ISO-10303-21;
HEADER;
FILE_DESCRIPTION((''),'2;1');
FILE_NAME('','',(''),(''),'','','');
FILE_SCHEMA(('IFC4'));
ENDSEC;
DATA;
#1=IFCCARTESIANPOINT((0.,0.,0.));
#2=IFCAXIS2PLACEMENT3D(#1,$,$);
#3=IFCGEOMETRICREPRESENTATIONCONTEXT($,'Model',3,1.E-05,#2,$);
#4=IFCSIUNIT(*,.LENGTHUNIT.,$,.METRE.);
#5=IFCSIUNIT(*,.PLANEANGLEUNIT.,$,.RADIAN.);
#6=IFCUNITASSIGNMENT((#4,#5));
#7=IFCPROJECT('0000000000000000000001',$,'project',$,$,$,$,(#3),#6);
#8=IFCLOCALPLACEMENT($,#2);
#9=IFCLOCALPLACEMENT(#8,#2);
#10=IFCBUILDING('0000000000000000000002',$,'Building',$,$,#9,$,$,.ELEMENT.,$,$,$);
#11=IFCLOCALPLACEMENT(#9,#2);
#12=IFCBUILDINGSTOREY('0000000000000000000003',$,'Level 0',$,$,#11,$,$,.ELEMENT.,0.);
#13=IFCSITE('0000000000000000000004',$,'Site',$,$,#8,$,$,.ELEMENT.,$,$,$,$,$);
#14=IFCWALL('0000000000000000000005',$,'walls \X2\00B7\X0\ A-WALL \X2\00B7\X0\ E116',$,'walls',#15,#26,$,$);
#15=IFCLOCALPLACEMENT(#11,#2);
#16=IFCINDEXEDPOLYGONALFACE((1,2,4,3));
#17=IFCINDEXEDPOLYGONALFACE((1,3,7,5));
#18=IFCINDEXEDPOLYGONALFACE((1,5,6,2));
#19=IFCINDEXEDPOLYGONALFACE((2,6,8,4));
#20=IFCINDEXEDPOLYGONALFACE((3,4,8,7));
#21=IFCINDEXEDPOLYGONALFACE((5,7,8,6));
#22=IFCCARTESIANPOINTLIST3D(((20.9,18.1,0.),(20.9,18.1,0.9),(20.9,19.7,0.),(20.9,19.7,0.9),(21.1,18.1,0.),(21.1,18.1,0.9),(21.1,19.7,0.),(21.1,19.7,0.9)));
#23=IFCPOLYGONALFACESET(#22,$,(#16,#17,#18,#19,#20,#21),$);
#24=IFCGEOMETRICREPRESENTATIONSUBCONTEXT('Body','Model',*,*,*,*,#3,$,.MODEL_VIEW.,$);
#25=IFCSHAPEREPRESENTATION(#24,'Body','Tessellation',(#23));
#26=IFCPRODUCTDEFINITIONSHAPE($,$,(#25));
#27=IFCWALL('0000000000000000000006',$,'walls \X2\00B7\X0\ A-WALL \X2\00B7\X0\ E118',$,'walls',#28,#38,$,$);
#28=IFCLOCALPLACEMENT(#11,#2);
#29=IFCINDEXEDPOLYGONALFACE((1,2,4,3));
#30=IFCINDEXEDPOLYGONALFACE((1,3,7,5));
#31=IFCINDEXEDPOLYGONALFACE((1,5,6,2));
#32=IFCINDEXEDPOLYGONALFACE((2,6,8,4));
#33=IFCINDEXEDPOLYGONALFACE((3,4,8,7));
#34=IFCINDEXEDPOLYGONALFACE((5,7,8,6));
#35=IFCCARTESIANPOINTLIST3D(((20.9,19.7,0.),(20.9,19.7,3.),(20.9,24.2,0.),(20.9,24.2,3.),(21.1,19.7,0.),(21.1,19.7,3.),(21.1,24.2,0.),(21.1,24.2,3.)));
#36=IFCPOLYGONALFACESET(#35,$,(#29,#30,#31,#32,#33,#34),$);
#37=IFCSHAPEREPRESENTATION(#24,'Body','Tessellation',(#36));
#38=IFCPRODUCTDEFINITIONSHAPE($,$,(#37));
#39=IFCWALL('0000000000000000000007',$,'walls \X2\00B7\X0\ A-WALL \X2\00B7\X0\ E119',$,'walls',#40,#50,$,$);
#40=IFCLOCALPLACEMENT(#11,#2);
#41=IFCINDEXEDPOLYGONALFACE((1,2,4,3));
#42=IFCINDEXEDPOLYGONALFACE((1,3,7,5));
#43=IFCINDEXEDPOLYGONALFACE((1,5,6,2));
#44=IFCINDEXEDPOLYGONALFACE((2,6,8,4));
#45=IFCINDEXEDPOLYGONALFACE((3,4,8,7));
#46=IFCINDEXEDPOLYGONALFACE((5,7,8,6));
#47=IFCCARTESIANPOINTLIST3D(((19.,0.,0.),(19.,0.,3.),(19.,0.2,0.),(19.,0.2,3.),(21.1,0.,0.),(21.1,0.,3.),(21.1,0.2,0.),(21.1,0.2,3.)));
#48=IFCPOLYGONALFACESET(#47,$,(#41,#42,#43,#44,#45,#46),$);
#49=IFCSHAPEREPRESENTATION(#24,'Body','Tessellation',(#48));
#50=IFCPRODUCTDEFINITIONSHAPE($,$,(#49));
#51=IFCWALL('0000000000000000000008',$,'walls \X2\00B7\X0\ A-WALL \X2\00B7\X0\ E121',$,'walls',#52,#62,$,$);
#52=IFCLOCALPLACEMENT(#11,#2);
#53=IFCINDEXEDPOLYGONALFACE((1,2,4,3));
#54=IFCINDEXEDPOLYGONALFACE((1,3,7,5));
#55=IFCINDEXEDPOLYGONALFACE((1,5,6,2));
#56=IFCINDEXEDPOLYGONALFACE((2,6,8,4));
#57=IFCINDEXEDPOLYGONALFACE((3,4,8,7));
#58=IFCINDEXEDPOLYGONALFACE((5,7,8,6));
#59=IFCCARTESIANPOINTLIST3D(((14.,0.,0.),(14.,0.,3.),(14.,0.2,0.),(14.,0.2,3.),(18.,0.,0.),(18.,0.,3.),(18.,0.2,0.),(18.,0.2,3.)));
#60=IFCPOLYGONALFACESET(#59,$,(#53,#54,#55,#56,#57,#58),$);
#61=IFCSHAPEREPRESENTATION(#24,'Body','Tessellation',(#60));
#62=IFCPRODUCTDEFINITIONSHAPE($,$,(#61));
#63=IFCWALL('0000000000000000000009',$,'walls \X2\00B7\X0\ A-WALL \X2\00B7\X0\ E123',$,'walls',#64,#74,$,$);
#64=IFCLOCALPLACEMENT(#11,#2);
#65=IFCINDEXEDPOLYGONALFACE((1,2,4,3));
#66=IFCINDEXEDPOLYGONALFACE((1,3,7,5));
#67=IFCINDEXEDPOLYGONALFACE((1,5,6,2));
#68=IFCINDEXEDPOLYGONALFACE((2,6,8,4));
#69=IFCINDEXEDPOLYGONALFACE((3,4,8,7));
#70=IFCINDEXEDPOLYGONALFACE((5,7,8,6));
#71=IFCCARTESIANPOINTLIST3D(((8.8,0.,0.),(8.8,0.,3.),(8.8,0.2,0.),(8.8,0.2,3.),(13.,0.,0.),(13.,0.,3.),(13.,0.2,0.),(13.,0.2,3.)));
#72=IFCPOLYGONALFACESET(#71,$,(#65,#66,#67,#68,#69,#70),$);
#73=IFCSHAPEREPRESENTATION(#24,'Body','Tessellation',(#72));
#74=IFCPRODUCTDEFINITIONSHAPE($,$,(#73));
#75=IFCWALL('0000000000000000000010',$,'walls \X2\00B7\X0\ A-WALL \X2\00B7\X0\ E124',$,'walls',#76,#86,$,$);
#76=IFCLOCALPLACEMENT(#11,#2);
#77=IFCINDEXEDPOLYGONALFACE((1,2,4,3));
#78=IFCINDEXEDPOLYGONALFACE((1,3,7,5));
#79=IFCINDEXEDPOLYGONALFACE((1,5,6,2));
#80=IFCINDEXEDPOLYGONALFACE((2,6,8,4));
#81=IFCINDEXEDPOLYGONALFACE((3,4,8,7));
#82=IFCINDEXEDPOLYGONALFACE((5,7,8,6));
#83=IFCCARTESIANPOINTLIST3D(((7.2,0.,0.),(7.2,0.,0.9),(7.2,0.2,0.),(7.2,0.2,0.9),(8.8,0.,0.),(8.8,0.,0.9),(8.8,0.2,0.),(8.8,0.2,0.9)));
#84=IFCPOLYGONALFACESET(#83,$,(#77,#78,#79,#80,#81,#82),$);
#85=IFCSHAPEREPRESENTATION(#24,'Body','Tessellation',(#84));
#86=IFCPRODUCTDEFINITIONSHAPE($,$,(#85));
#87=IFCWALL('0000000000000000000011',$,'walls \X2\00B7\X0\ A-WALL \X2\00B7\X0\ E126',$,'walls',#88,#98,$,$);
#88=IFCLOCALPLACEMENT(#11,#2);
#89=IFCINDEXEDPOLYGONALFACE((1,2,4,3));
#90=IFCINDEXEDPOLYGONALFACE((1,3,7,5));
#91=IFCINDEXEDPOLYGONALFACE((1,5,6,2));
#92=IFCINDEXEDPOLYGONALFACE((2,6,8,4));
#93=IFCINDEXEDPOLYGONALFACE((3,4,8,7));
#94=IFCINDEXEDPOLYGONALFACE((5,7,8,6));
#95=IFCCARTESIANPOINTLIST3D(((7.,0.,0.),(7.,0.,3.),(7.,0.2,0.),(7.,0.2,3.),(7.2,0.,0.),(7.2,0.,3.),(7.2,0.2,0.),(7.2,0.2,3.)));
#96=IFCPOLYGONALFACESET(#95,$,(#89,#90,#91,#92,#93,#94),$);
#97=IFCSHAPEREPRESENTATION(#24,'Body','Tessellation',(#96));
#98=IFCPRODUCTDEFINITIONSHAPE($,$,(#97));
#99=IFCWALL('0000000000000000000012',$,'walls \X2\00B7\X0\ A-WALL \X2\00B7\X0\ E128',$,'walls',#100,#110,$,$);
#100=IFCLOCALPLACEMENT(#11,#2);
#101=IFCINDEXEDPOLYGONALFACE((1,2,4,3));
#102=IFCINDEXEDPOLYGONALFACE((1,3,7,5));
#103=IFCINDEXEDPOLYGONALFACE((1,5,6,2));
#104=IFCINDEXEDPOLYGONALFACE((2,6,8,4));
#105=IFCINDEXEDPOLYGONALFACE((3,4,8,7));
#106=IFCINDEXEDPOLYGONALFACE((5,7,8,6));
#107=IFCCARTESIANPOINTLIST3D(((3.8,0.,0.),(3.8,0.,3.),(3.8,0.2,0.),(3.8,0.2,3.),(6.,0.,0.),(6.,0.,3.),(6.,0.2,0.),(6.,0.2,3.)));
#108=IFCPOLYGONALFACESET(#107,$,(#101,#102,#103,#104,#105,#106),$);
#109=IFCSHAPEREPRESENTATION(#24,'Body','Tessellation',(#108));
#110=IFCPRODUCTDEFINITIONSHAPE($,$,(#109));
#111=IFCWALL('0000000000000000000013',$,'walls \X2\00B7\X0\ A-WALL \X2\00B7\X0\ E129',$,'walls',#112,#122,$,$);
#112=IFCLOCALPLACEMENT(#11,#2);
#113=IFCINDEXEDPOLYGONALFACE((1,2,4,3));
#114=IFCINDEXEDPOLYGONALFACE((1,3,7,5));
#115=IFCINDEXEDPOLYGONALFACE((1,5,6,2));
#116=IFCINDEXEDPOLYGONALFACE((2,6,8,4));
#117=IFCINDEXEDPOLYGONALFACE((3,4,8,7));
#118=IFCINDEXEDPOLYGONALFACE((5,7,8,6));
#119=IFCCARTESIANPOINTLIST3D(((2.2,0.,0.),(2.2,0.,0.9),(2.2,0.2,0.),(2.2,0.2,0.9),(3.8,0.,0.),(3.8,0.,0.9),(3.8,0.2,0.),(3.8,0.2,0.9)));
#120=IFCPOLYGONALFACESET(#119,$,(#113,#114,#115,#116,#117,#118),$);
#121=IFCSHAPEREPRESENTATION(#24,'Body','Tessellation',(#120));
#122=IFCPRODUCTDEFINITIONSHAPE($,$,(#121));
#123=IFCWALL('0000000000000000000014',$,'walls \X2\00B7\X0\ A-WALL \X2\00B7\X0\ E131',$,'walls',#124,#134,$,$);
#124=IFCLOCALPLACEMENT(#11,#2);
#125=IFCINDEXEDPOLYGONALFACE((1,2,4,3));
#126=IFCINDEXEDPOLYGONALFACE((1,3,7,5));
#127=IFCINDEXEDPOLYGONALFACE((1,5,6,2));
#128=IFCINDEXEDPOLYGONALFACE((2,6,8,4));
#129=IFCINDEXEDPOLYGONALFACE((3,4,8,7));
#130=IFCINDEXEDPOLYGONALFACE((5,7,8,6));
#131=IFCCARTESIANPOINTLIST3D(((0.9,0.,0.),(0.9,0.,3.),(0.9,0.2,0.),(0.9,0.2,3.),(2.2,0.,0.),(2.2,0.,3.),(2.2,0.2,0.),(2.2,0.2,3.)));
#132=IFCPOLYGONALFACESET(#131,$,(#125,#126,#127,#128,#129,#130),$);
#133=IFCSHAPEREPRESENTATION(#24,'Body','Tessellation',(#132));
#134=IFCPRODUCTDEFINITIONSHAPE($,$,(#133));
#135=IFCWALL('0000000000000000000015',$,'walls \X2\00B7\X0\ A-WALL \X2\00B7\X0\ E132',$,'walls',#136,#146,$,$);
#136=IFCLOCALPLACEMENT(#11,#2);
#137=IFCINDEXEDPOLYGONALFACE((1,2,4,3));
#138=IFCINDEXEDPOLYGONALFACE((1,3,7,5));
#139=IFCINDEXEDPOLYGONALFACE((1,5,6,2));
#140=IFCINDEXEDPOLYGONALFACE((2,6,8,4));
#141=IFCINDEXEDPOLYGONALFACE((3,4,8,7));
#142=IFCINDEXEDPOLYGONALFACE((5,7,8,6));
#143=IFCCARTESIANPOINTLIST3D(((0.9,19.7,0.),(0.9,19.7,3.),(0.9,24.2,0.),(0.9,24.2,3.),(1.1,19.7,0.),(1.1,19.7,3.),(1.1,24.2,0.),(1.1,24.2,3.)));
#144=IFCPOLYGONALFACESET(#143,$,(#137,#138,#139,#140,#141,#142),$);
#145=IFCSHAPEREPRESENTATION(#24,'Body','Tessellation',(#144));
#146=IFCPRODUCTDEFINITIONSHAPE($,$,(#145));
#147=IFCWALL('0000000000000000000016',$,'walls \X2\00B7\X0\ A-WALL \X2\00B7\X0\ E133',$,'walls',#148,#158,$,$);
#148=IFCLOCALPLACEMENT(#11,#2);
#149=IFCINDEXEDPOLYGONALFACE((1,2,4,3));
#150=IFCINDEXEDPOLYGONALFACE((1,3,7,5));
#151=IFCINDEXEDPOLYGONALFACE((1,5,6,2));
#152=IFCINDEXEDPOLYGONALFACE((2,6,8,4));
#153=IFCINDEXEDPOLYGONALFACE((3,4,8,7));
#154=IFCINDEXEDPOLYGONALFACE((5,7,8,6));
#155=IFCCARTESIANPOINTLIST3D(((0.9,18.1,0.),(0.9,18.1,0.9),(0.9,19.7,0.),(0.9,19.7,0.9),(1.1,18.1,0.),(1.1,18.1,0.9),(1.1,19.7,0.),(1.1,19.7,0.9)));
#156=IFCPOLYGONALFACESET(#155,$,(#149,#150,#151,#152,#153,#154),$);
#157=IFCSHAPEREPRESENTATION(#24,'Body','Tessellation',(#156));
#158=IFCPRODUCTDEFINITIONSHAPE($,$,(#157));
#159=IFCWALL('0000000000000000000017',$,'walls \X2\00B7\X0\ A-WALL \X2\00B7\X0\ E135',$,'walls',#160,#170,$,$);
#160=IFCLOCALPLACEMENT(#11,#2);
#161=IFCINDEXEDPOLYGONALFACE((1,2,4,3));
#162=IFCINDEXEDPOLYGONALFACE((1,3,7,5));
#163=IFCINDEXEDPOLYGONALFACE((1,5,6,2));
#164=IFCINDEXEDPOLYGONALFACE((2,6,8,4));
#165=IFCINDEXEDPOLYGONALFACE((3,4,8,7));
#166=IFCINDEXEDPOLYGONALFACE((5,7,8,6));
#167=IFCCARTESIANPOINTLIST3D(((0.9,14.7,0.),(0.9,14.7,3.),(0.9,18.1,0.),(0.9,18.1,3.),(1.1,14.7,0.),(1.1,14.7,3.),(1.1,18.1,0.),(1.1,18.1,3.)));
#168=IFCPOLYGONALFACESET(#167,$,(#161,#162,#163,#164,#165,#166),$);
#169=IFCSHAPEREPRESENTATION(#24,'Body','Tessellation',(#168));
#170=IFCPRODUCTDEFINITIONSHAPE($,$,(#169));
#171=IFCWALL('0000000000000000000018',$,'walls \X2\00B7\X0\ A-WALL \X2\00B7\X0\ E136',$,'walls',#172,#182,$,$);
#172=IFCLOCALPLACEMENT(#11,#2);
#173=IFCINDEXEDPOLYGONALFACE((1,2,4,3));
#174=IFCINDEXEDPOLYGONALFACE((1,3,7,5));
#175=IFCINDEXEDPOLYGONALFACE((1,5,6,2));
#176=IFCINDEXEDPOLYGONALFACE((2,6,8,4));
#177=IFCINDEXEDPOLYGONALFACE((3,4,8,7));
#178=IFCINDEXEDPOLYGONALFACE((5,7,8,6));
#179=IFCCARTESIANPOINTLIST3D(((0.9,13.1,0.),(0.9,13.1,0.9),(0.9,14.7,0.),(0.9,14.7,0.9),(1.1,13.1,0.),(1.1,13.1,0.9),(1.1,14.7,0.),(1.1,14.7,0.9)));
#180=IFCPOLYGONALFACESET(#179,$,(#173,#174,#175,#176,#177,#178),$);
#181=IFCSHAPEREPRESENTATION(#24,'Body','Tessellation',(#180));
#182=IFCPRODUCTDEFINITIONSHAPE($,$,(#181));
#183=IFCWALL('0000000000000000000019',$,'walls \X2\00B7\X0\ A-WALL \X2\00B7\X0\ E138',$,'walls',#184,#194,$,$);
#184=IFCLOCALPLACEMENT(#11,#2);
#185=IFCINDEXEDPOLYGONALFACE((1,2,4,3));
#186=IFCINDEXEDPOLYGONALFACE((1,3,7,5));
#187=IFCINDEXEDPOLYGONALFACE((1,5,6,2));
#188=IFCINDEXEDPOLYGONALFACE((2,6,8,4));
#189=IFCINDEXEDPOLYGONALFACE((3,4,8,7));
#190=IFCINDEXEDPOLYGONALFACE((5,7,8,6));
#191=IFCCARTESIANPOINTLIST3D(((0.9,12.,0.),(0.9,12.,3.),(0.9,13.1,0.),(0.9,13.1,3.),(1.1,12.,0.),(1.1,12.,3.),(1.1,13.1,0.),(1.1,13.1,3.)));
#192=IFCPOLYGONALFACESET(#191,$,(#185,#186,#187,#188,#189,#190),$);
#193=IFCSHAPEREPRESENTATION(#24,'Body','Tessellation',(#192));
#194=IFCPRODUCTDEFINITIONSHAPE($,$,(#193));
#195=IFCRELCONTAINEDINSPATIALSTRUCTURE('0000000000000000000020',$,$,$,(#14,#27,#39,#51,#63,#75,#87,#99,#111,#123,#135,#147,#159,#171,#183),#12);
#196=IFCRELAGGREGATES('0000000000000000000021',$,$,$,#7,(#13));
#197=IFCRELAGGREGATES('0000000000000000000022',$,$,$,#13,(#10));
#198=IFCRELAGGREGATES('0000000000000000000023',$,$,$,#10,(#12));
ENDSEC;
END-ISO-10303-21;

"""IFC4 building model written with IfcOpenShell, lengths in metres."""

from ifc_helpers import new_model, si_unit, frame, origin, place, context, subcontext, project, spatial, polyline, outline, extrude, element, save


model = new_model("IFC4")

# Units and contexts
model_context = context("Model", 3, precision=1e-05, world=origin())
body_context = subcontext(model_context, "Body", "Model", "MODEL_VIEW")
ifc_project = project(units=[si_unit("LENGTHUNIT", "METRE"), si_unit("PLANEANGLEUNIT", "RADIAN")], contexts=[model_context])

# Site, building, storey
site_placement = place(None, origin())
site = spatial("IfcSite", under=ifc_project, at=site_placement, Name="Site", CompositionType="ELEMENT")
building_placement = place(site_placement, origin())
building = spatial("IfcBuilding", under=site, at=building_placement, Name="Building", CompositionType="ELEMENT")
storey_placement = place(building_placement, origin())
storey = spatial("IfcBuildingStorey", under=building, at=storey_placement, Name="Level 0", CompositionType="ELEMENT", Elevation=0.0)

# Wall, opening
wall_1_placement = place(storey_placement, origin())
wall_1 = element("IfcWall", 1, at=wall_1_placement, inside=storey, Name="walls · A-WALL · E116", ObjectType="walls", context=body_context, shape_type="SweptSolid", body=[
    extrude(outline(polyline([(21.1, 18.1), (21.1, 19.7), (20.9, 19.7), (20.9, 18.1), (21.1, 18.1)])), origin(), (0.0, 0.0, 1.0), 0.9),
])
opening_1_placement = place(storey_placement, frame((0.0, 0.0, 0.9)))
element("IfcOpeningElement", 2, at=opening_1_placement, cuts=wall_1, ObjectType="Opening", context=body_context, shape_type="SweptSolid", body=[
    extrude(outline(polyline([(21.1, 18.1), (21.1, 19.7), (20.9, 19.7), (20.9, 18.1), (21.1, 18.1)])), origin(), (0.0, 0.0, 1.0), 1.4),
])

# Walls
wall_2_placement = place(storey_placement, origin())
element("IfcWall", 3, at=wall_2_placement, inside=storey, Name="walls · A-WALL · E118", ObjectType="walls", context=body_context, shape_type="SweptSolid", body=[
    extrude(outline(polyline([(21.1, 19.7), (21.1, 24.2), (20.9, 24.2), (20.9, 19.7), (21.1, 19.7)])), origin(), (0.0, 0.0, 1.0), 3.0),
])
wall_3_placement = place(storey_placement, origin())
element("IfcWall", 4, at=wall_3_placement, inside=storey, Name="walls · A-WALL · E119", ObjectType="walls", context=body_context, shape_type="SweptSolid", body=[
    extrude(outline(polyline([(21.1, 0.2), (19.0, 0.2), (19.0, 0.0), (21.1, 0.0), (21.1, 0.2)])), origin(), (0.0, 0.0, 1.0), 3.0),
])
wall_4_placement = place(storey_placement, origin())
element("IfcWall", 5, at=wall_4_placement, inside=storey, Name="walls · A-WALL · E121", ObjectType="walls", context=body_context, shape_type="SweptSolid", body=[
    extrude(outline(polyline([(18.0, 0.2), (14.0, 0.2), (14.0, 0.0), (18.0, 0.0), (18.0, 0.2)])), origin(), (0.0, 0.0, 1.0), 3.0),
])
wall_5_placement = place(storey_placement, origin())
element("IfcWall", 6, at=wall_5_placement, inside=storey, Name="walls · A-WALL · E123", ObjectType="walls", context=body_context, shape_type="SweptSolid", body=[
    extrude(outline(polyline([(13.0, 0.2), (8.8, 0.2), (8.8, 0.0), (13.0, 0.0), (13.0, 0.2)])), origin(), (0.0, 0.0, 1.0), 3.0),
])

# Wall, opening
wall_6_placement = place(storey_placement, origin())
wall_6 = element("IfcWall", 7, at=wall_6_placement, inside=storey, Name="walls · A-WALL · E124", ObjectType="walls", context=body_context, shape_type="SweptSolid", body=[
    extrude(outline(polyline([(8.8, 0.2), (7.2, 0.2), (7.2, 0.0), (8.8, 0.0), (8.8, 0.2)])), origin(), (0.0, 0.0, 1.0), 0.9),
])
opening_2_placement = place(storey_placement, frame((0.0, 0.0, 0.9)))
element("IfcOpeningElement", 8, at=opening_2_placement, cuts=wall_6, ObjectType="Opening", context=body_context, shape_type="SweptSolid", body=[
    extrude(outline(polyline([(8.8, 0.2), (7.2, 0.2), (7.2, 0.0), (8.8, 0.0), (8.8, 0.2)])), origin(), (0.0, 0.0, 1.0), 1.4),
])

# Walls
wall_7_placement = place(storey_placement, origin())
element("IfcWall", 9, at=wall_7_placement, inside=storey, Name="walls · A-WALL · E126", ObjectType="walls", context=body_context, shape_type="SweptSolid", body=[
    extrude(outline(polyline([(7.2, 0.2), (7.0, 0.2), (7.0, 0.0), (7.2, 0.0), (7.2, 0.2)])), origin(), (0.0, 0.0, 1.0), 3.0),
])
wall_8_placement = place(storey_placement, origin())
element("IfcWall", 10, at=wall_8_placement, inside=storey, Name="walls · A-WALL · E128", ObjectType="walls", context=body_context, shape_type="SweptSolid", body=[
    extrude(outline(polyline([(6.0, 0.2), (3.8, 0.2), (3.8, 0.0), (6.0, 0.0), (6.0, 0.2)])), origin(), (0.0, 0.0, 1.0), 3.0),
])

# Wall, opening
wall_9_placement = place(storey_placement, origin())
wall_9 = element("IfcWall", 11, at=wall_9_placement, inside=storey, Name="walls · A-WALL · E129", ObjectType="walls", context=body_context, shape_type="SweptSolid", body=[
    extrude(outline(polyline([(3.8, 0.2), (2.2, 0.2), (2.2, 0.0), (3.8, 0.0), (3.8, 0.2)])), origin(), (0.0, 0.0, 1.0), 0.9),
])
opening_3_placement = place(storey_placement, frame((0.0, 0.0, 0.9)))
element("IfcOpeningElement", 12, at=opening_3_placement, cuts=wall_9, ObjectType="Opening", context=body_context, shape_type="SweptSolid", body=[
    extrude(outline(polyline([(3.8, 0.2), (2.2, 0.2), (2.2, 0.0), (3.8, 0.0), (3.8, 0.2)])), origin(), (0.0, 0.0, 1.0), 1.4),
])

# Walls
wall_10_placement = place(storey_placement, origin())
element("IfcWall", 13, at=wall_10_placement, inside=storey, Name="walls · A-WALL · E131", ObjectType="walls", context=body_context, shape_type="SweptSolid", body=[
    extrude(outline(polyline([(2.2, 0.2), (0.9, 0.2), (0.9, 0.0), (2.2, 0.0), (2.2, 0.2)])), origin(), (0.0, 0.0, 1.0), 3.0),
])
wall_11_placement = place(storey_placement, origin())
element("IfcWall", 14, at=wall_11_placement, inside=storey, Name="walls · A-WALL · E132", ObjectType="walls", context=body_context, shape_type="SweptSolid", body=[
    extrude(outline(polyline([(0.9, 24.2), (0.9, 19.7), (1.1, 19.7), (1.1, 24.2), (0.9, 24.2)])), origin(), (0.0, 0.0, 1.0), 3.0),
])

# Wall, opening
wall_12_placement = place(storey_placement, origin())
wall_12 = element("IfcWall", 15, at=wall_12_placement, inside=storey, Name="walls · A-WALL · E133", ObjectType="walls", context=body_context, shape_type="SweptSolid", body=[
    extrude(outline(polyline([(0.9, 19.7), (0.9, 18.1), (1.1, 18.1), (1.1, 19.7), (0.9, 19.7)])), origin(), (0.0, 0.0, 1.0), 0.9),
])
opening_4_placement = place(storey_placement, frame((0.0, 0.0, 0.9)))
element("IfcOpeningElement", 16, at=opening_4_placement, cuts=wall_12, ObjectType="Opening", context=body_context, shape_type="SweptSolid", body=[
    extrude(outline(polyline([(0.9, 19.7), (0.9, 18.1), (1.1, 18.1), (1.1, 19.7), (0.9, 19.7)])), origin(), (0.0, 0.0, 1.0), 1.4),
])

# Wall
wall_13_placement = place(storey_placement, origin())
element("IfcWall", 17, at=wall_13_placement, inside=storey, Name="walls · A-WALL · E135", ObjectType="walls", context=body_context, shape_type="SweptSolid", body=[
    extrude(outline(polyline([(0.9, 18.1), (0.9, 14.7), (1.1, 14.7), (1.1, 18.1), (0.9, 18.1)])), origin(), (0.0, 0.0, 1.0), 3.0),
])

# Wall, opening
wall_14_placement = place(storey_placement, origin())
wall_14 = element("IfcWall", 18, at=wall_14_placement, inside=storey, Name="walls · A-WALL · E136", ObjectType="walls", context=body_context, shape_type="SweptSolid", body=[
    extrude(outline(polyline([(0.9, 14.7), (0.9, 13.1), (1.1, 13.1), (1.1, 14.7), (0.9, 14.7)])), origin(), (0.0, 0.0, 1.0), 0.9),
])
opening_5_placement = place(storey_placement, frame((0.0, 0.0, 0.9)))
element("IfcOpeningElement", 19, at=opening_5_placement, cuts=wall_14, ObjectType="Opening", context=body_context, shape_type="SweptSolid", body=[
    extrude(outline(polyline([(0.9, 14.7), (0.9, 13.1), (1.1, 13.1), (1.1, 14.7), (0.9, 14.7)])), origin(), (0.0, 0.0, 1.0), 1.4),
])

# Wall
wall_15_placement = place(storey_placement, origin())
element("IfcWall", 20, at=wall_15_placement, inside=storey, Name="walls · A-WALL · E138", ObjectType="walls", context=body_context, shape_type="SweptSolid", body=[
    extrude(outline(polyline([(0.9, 13.1), (0.9, 12.0), (1.1, 12.0), (1.1, 13.1), (0.9, 13.1)])), origin(), (0.0, 0.0, 1.0), 3.0),
])

save(model, "model.ifc")
